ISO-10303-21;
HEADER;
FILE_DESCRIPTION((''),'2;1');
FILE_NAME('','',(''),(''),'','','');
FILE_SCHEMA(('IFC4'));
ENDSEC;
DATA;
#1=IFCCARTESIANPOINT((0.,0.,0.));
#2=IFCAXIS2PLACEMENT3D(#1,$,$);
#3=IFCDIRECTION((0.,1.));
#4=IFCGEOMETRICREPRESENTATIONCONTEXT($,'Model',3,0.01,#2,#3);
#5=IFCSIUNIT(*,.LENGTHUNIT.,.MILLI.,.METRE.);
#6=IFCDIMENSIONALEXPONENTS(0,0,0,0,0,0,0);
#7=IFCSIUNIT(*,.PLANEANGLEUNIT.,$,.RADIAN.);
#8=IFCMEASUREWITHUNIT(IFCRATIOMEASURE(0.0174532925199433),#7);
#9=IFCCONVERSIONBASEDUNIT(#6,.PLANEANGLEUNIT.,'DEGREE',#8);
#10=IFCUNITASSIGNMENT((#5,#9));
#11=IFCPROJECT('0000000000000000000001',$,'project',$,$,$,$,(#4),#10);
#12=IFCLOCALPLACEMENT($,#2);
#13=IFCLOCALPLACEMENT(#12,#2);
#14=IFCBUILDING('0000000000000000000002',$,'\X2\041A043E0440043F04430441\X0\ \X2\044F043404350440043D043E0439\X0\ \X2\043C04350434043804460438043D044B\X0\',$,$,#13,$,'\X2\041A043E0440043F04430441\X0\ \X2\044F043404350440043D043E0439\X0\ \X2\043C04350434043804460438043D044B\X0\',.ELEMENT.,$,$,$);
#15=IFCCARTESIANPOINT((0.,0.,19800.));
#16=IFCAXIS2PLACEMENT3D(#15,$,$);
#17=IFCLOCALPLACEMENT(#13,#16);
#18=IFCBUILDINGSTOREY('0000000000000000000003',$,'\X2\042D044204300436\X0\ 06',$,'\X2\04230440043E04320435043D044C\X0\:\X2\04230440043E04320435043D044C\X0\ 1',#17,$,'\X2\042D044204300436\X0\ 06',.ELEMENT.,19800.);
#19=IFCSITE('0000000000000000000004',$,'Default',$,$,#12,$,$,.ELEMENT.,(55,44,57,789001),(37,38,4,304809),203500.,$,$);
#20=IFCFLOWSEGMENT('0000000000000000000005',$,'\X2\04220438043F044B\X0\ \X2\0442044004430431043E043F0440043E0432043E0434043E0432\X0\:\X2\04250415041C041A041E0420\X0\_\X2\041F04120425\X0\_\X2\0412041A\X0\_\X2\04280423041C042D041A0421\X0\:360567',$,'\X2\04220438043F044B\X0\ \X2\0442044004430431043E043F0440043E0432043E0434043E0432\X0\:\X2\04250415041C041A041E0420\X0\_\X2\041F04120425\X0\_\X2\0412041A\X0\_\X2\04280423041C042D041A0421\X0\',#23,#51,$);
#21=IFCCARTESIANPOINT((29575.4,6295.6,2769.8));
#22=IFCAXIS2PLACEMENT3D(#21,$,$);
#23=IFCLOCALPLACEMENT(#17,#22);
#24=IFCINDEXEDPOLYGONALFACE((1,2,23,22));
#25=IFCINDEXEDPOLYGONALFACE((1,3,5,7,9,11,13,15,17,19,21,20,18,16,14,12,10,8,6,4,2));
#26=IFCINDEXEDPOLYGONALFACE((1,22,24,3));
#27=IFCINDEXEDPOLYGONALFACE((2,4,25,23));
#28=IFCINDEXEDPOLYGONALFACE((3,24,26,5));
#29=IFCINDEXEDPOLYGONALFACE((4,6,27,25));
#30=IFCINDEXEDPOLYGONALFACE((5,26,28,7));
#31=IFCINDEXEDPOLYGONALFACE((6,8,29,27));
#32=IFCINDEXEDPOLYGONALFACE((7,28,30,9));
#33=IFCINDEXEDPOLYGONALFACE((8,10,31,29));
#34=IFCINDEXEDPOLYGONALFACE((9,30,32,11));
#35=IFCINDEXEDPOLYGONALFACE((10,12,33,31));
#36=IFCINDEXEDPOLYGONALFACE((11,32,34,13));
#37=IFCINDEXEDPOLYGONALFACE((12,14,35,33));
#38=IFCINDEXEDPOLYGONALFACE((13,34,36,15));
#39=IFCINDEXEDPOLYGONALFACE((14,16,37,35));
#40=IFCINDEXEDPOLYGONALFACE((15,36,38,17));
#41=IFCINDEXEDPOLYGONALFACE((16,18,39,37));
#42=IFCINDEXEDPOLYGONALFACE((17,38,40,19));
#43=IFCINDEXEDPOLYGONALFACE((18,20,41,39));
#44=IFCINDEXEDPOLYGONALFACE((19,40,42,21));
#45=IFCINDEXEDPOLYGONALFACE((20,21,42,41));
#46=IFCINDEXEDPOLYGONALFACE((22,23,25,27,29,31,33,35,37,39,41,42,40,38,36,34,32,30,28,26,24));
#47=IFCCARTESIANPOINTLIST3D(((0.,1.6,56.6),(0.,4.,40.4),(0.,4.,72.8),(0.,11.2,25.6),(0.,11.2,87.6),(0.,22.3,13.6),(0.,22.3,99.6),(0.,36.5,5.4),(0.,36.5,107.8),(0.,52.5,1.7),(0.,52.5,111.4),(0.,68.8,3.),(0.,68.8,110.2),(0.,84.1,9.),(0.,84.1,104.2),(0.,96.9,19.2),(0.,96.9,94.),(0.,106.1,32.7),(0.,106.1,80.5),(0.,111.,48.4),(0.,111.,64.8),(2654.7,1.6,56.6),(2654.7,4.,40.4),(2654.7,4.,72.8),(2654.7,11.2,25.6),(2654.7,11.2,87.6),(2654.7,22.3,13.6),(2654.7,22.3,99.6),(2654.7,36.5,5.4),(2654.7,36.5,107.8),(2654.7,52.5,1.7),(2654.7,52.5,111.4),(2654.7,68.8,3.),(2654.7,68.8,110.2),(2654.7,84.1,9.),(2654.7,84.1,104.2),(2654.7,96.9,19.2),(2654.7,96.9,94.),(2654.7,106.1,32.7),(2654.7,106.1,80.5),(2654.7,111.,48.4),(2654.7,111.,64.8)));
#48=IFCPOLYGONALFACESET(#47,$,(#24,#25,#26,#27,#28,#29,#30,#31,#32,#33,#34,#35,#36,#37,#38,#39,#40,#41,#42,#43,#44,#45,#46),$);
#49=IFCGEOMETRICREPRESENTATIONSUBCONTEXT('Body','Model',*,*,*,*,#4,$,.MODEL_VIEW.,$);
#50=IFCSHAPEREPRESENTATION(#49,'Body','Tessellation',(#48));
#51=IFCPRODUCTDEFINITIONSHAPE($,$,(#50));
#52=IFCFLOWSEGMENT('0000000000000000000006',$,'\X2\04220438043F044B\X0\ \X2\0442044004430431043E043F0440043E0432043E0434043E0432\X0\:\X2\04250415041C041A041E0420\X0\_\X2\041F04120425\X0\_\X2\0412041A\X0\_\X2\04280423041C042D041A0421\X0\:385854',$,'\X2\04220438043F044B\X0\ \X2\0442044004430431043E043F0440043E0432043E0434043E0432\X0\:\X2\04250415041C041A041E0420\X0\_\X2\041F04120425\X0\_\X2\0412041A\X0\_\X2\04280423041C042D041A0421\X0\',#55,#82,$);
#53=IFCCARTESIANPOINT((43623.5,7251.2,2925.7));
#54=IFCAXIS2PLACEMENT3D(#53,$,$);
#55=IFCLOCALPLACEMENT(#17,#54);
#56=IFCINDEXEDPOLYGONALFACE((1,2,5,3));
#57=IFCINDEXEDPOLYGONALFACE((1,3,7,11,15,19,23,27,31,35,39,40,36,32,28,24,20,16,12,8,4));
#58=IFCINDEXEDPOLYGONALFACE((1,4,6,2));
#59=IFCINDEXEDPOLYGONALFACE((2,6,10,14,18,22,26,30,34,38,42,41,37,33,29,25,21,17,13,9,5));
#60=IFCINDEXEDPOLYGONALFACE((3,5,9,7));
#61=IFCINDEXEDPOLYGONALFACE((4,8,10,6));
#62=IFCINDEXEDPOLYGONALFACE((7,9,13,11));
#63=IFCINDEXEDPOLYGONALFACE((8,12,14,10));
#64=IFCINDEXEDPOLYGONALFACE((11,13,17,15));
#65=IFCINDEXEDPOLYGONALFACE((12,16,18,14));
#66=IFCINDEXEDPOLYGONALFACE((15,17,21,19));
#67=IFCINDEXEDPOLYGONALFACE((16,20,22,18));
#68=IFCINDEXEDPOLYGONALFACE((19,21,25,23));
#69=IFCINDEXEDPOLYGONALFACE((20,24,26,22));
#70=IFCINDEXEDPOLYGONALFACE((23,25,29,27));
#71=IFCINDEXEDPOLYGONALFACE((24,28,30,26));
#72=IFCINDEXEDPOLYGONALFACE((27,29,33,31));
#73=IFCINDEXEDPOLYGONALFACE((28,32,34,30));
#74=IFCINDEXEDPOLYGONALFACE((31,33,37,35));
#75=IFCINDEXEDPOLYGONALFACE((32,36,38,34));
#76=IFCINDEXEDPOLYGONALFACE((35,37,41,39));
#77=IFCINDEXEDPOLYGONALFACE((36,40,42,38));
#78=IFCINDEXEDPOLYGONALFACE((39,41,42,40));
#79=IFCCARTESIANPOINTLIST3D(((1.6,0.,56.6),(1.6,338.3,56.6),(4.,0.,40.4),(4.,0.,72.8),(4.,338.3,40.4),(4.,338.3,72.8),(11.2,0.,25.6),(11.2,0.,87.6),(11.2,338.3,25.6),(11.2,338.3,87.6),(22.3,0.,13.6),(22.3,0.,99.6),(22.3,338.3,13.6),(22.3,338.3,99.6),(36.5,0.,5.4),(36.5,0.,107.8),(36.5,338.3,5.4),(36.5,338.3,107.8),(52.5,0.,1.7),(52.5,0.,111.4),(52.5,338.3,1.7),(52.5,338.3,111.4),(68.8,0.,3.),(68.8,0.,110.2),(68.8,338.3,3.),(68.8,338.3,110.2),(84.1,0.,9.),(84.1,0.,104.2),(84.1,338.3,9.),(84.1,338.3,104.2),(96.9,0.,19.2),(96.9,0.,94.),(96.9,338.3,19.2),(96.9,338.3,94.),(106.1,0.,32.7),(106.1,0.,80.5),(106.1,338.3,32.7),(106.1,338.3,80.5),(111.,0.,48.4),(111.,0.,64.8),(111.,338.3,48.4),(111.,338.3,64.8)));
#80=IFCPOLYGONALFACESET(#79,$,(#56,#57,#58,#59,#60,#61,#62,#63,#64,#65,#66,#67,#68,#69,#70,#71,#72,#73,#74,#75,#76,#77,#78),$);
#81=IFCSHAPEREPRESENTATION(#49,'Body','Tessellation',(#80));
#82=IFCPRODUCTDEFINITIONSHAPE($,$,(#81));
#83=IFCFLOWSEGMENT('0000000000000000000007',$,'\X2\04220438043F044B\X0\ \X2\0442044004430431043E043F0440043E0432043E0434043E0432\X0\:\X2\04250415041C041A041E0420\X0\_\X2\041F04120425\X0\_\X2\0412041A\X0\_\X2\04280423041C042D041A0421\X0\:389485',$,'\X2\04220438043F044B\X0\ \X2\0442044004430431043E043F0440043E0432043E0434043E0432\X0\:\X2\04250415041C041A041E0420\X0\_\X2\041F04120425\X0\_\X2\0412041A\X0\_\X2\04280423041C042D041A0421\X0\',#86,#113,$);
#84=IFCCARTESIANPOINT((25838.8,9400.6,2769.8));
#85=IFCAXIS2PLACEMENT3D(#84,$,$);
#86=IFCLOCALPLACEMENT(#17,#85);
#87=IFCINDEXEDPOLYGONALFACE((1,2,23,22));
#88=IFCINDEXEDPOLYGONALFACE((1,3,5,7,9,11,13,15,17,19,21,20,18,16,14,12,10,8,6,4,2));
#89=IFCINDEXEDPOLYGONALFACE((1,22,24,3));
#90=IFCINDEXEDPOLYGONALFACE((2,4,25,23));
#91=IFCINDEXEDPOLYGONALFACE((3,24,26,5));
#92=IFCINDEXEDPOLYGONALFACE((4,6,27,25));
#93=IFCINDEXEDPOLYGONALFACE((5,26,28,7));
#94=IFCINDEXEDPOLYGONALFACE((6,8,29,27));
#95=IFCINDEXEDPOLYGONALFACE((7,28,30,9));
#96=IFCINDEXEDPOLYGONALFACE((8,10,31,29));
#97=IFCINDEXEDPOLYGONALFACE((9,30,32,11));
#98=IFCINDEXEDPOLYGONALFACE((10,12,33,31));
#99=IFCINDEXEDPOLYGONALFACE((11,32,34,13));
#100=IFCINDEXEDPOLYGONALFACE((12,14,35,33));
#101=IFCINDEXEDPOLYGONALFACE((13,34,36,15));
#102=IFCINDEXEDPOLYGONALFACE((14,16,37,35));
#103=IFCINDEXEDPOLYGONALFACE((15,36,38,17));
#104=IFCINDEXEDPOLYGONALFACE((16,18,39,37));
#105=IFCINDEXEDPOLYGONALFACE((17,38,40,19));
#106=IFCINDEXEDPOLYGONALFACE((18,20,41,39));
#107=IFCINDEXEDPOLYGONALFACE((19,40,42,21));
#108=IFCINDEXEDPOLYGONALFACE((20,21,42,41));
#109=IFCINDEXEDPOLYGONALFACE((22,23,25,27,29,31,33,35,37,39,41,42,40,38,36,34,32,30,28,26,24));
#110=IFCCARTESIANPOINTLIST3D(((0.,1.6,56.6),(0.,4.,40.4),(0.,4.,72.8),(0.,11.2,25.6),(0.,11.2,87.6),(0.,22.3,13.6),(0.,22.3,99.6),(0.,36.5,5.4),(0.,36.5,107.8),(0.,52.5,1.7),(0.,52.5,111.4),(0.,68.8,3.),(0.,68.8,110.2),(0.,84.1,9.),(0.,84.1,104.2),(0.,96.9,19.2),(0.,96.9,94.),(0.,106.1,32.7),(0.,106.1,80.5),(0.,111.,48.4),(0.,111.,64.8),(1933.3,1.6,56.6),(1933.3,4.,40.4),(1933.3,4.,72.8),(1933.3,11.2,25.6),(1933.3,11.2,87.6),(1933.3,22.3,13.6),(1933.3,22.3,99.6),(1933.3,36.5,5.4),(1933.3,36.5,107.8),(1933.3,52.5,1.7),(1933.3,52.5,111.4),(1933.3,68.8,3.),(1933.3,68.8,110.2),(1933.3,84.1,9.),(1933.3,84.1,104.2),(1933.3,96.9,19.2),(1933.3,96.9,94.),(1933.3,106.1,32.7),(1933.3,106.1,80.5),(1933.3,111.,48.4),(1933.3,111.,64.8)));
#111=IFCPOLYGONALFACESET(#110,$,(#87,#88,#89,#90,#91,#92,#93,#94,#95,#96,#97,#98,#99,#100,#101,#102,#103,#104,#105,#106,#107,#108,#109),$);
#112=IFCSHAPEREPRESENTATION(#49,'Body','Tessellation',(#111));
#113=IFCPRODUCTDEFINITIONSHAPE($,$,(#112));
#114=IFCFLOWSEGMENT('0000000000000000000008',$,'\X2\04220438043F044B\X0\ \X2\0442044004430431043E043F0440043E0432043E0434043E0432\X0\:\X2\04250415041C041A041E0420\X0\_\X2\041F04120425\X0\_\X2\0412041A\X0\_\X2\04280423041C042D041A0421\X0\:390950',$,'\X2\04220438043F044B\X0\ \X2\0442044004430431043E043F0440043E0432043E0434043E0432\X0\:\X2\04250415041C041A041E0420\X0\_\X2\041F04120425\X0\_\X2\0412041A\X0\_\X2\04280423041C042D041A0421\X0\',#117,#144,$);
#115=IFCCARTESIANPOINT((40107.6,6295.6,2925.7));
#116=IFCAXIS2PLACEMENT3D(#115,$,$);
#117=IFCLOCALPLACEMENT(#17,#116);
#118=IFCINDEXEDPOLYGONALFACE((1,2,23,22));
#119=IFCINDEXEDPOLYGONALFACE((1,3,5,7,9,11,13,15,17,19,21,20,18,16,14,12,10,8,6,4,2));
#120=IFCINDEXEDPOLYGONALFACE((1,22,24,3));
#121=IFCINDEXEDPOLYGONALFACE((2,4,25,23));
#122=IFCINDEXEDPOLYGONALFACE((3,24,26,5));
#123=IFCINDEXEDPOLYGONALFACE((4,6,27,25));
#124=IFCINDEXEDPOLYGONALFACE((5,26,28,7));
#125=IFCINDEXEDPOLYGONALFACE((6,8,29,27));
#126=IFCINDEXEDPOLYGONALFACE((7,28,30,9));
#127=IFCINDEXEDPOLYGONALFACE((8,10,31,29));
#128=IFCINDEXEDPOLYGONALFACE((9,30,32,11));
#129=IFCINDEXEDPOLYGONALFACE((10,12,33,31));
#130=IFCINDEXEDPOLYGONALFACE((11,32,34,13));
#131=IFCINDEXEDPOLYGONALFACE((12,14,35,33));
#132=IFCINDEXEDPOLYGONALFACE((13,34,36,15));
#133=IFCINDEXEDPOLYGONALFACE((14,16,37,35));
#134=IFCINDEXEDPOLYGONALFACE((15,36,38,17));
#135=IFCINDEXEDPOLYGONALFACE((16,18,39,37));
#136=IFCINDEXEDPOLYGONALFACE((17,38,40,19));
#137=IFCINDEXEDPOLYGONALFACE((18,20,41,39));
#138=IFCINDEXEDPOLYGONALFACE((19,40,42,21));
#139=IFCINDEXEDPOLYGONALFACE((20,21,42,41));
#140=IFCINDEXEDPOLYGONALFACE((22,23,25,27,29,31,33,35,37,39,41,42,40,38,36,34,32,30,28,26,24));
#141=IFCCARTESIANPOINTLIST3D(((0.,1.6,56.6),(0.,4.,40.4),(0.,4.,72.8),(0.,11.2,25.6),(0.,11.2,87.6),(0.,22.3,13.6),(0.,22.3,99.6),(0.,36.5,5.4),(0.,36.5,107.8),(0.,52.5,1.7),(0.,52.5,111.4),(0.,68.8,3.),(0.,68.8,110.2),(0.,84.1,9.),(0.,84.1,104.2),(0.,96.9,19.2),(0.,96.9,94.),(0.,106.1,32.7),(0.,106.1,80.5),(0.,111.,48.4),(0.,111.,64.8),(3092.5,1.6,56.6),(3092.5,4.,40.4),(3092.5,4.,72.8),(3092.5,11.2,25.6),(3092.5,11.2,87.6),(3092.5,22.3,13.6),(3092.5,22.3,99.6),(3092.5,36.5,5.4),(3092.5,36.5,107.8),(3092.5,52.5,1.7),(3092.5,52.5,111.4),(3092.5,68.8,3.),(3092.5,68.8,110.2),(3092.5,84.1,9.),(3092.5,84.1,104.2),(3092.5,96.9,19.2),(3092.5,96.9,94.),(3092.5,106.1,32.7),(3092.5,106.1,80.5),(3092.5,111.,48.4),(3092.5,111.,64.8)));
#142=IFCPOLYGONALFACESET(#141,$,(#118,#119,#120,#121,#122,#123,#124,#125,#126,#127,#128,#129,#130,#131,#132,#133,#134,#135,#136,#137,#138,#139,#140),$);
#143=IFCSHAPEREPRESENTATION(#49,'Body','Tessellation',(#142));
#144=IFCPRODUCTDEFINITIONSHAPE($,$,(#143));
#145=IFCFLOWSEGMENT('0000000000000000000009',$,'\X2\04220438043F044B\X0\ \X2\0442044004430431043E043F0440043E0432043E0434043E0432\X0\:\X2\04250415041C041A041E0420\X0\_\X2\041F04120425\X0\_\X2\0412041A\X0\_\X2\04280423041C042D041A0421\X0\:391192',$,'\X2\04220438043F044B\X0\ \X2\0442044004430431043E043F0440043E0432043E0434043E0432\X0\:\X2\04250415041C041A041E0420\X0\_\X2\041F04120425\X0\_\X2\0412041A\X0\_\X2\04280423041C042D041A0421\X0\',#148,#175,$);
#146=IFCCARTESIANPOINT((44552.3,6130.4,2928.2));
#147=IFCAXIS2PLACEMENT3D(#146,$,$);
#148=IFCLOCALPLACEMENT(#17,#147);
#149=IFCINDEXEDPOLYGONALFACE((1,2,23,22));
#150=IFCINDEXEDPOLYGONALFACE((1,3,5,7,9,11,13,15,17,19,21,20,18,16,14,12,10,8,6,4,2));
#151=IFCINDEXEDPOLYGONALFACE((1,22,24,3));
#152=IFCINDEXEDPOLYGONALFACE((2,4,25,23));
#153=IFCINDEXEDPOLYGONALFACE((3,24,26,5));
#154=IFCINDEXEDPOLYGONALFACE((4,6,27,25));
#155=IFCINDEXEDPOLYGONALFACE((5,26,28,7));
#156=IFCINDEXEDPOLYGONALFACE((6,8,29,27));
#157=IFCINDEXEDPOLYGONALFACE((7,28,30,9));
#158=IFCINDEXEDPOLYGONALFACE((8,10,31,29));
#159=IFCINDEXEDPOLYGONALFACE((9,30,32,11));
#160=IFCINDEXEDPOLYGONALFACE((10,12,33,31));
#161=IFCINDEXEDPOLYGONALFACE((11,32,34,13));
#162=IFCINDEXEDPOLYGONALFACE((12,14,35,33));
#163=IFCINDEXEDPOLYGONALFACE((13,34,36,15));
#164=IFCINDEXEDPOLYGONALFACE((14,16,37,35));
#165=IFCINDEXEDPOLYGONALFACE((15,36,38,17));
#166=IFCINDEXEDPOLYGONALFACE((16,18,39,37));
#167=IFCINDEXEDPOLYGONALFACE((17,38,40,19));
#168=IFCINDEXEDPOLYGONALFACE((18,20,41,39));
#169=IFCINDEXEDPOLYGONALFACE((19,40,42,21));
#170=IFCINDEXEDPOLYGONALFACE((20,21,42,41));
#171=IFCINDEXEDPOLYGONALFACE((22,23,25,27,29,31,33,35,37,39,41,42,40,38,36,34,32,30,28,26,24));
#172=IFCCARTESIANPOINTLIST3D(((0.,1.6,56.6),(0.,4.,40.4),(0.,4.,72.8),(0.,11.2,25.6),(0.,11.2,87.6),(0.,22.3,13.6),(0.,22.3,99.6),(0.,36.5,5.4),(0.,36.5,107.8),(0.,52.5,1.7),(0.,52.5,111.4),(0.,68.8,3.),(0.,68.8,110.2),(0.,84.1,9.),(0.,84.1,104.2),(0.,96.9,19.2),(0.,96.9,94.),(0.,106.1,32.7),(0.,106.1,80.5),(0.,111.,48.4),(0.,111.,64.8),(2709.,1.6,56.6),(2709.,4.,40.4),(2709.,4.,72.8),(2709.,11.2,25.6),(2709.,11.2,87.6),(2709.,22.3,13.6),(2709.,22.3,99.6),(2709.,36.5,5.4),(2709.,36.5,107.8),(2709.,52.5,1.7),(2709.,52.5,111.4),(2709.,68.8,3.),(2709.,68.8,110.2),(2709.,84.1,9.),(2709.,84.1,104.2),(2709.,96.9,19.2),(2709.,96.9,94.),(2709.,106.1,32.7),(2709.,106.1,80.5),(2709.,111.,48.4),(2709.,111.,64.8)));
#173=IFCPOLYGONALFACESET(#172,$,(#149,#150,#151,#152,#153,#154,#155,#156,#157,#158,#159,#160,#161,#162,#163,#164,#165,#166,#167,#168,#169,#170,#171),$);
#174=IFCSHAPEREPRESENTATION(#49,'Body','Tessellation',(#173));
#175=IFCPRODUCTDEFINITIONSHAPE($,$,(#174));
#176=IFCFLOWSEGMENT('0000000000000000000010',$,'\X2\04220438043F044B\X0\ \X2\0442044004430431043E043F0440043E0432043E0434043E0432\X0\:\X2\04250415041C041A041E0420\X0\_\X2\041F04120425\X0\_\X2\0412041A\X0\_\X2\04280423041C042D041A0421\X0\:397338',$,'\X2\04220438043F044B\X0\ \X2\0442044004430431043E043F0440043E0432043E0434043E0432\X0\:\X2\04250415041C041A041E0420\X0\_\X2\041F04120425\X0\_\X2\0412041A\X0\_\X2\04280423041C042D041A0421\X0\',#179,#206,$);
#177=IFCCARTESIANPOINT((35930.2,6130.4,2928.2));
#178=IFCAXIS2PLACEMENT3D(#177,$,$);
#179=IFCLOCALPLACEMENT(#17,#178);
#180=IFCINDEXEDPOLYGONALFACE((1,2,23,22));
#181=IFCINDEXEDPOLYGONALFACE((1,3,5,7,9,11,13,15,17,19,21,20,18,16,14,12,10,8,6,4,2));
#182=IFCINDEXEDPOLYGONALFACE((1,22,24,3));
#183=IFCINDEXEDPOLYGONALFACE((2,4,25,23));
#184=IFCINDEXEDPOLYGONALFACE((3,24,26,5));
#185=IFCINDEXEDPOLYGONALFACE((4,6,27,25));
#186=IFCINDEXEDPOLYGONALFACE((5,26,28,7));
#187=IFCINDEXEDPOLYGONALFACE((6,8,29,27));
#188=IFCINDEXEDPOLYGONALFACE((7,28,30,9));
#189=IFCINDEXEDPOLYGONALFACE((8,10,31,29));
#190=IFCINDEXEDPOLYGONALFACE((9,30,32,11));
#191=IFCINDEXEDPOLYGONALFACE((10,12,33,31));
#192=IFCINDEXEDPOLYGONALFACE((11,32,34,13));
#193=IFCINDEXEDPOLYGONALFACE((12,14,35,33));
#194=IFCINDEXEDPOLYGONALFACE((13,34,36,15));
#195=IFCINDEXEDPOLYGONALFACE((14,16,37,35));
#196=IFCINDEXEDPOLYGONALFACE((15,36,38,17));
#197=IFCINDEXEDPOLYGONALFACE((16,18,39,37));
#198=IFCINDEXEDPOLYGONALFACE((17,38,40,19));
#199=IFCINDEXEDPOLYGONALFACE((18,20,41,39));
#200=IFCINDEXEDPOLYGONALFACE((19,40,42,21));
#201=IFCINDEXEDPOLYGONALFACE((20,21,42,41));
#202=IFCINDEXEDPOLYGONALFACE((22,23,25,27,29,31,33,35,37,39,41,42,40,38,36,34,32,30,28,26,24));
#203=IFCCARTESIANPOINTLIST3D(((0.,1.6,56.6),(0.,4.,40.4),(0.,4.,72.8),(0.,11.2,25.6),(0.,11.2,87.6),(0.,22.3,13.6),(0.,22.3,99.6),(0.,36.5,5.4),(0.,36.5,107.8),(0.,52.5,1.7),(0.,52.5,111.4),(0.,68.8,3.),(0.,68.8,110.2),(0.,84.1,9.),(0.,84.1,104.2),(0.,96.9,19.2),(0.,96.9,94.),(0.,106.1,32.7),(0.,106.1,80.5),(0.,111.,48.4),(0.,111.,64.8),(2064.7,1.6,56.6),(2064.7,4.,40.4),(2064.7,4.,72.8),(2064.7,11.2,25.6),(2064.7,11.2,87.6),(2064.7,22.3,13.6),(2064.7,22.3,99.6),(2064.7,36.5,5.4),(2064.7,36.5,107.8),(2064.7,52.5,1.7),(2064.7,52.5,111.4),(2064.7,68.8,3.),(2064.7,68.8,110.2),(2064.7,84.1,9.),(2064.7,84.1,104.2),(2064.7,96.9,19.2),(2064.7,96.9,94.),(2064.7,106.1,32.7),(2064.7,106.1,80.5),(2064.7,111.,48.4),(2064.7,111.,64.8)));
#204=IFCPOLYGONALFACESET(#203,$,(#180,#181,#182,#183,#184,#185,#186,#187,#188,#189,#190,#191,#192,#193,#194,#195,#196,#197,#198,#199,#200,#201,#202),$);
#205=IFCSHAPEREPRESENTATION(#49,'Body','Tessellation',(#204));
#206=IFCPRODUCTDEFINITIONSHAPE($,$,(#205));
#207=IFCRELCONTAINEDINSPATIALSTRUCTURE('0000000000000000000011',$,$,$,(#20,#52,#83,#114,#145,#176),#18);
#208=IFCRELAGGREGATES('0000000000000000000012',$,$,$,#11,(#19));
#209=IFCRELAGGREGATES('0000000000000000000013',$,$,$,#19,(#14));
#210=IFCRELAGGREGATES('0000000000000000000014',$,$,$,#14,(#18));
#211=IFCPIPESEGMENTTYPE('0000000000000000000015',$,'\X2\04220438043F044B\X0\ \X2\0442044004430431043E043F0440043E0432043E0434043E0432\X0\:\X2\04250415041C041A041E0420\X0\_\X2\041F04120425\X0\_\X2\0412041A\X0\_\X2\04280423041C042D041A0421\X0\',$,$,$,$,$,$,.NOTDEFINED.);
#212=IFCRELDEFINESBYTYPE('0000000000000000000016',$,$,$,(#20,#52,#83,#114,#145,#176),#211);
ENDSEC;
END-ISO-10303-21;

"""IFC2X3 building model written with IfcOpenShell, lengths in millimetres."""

from ifc_helpers import new_model, entity, si_unit, converted_unit, direction, frame, origin, origin_2d_with_axis, place, context, subcontext, project, spatial, circle, extrude, type_object, element, save


model = new_model("IFC2X3")

# Units and contexts
model_context = context("Model", 3, precision=0.01, world=origin(), true_north=direction((0.0, 1.0)))
body_context = subcontext(model_context, "Body", "Model", "MODEL_VIEW")
ifc_project = project(units=[si_unit("LENGTHUNIT", "METRE", prefix="MILLI"), converted_unit("PLANEANGLEUNIT", "DEGREE", entity("IfcRatioMeasure", 0.0174532925199433), si_unit("PLANEANGLEUNIT", "RADIAN"), dimensions=[0, 0, 0, 0, 0, 0, 0])], contexts=[model_context])

# Site, building, storey
site_placement = place(None, frame((0.0, 0.0, 0.0)))
site = spatial("IfcSite", under=ifc_project, at=site_placement, Name="Default", CompositionType="ELEMENT", RefLatitude=(55, 44, 57, 789001), RefLongitude=(37, 38, 4, 304809), RefElevation=203500.0)
building_placement = place(site_placement, origin())
building = spatial("IfcBuilding", under=site, at=building_placement, Name="Корпус ядерной медицины", LongName="Корпус ядерной медицины", CompositionType="ELEMENT")
storey_placement = place(building_placement, frame((0.0, 0.0, 19800.0)))
storey = spatial("IfcBuildingStorey", under=building, at=storey_placement, Name="Этаж 06", ObjectType="Уровень:Уровень 1", LongName="Этаж 06", CompositionType="ELEMENT", Elevation=19800.0)

# Flow segments
pipe_segment_type = type_object("IfcPipeSegmentType", Name="Типы трубопроводов:ХЕМКОР_ПВХ_ВК_ШУМЭКС", PredefinedType="NOTDEFINED")
flow_segment_1_placement = place(storey_placement, frame((29575.4, 6295.6, 2769.8)))
element("IfcFlowSegment", 1, at=flow_segment_1_placement, inside=storey, type_object=pipe_segment_type, Name="Типы трубопроводов:ХЕМКОР_ПВХ_ВК_ШУМЭКС:360567", ObjectType="Типы трубопроводов:ХЕМКОР_ПВХ_ВК_ШУМЭКС", context=body_context, shape_type="SweptSolid", body=[
    extrude(circle(Radius=55.0, at=origin_2d_with_axis()), frame((0.0, 56.6, 56.6), z_axis=(1.0, 0.0, 0.0), x_axis=(0.0, -1.0, 0.0)), (0.0, 0.0, 1.0), 2654.7),
])
flow_segment_2_placement = place(storey_placement, frame((43623.5, 7251.2, 2925.7)))
element("IfcFlowSegment", 2, at=flow_segment_2_placement, inside=storey, type_object=pipe_segment_type, Name="Типы трубопроводов:ХЕМКОР_ПВХ_ВК_ШУМЭКС:385854", ObjectType="Типы трубопроводов:ХЕМКОР_ПВХ_ВК_ШУМЭКС", context=body_context, shape_type="SweptSolid", body=[
    extrude(circle(Radius=55.0, at=origin_2d_with_axis()), frame((56.6, 0.0, 56.6), z_axis=(0.0, 1.0, 0.0), x_axis=(-1.0, 0.0, 0.0)), (0.0, 0.0, 1.0), 338.3),
])
flow_segment_3_placement = place(storey_placement, frame((25838.8, 9400.6, 2769.8)))
element("IfcFlowSegment", 3, at=flow_segment_3_placement, inside=storey, type_object=pipe_segment_type, Name="Типы трубопроводов:ХЕМКОР_ПВХ_ВК_ШУМЭКС:389485", ObjectType="Типы трубопроводов:ХЕМКОР_ПВХ_ВК_ШУМЭКС", context=body_context, shape_type="SweptSolid", body=[
    extrude(circle(Radius=55.0, at=origin_2d_with_axis()), frame((0.0, 56.6, 56.6), z_axis=(1.0, 0.0, 0.0), x_axis=(0.0, -1.0, 0.0)), (0.0, 0.0, 1.0), 1933.3),
])
flow_segment_4_placement = place(storey_placement, frame((40107.6, 6295.6, 2925.7)))
element("IfcFlowSegment", 4, at=flow_segment_4_placement, inside=storey, type_object=pipe_segment_type, Name="Типы трубопроводов:ХЕМКОР_ПВХ_ВК_ШУМЭКС:390950", ObjectType="Типы трубопроводов:ХЕМКОР_ПВХ_ВК_ШУМЭКС", context=body_context, shape_type="SweptSolid", body=[
    extrude(circle(Radius=55.0, at=origin_2d_with_axis()), frame((0.0, 56.6, 56.6), z_axis=(1.0, 0.0, 0.0), x_axis=(0.0, -1.0, 0.0)), (0.0, 0.0, 1.0), 3092.5),
])
flow_segment_5_placement = place(storey_placement, frame((44552.3, 6130.4, 2928.2)))
element("IfcFlowSegment", 5, at=flow_segment_5_placement, inside=storey, type_object=pipe_segment_type, Name="Типы трубопроводов:ХЕМКОР_ПВХ_ВК_ШУМЭКС:391192", ObjectType="Типы трубопроводов:ХЕМКОР_ПВХ_ВК_ШУМЭКС", context=body_context, shape_type="SweptSolid", body=[
    extrude(circle(Radius=55.0, at=origin_2d_with_axis()), frame((0.0, 56.6, 56.6), z_axis=(1.0, 0.0, 0.0), x_axis=(0.0, -1.0, 0.0)), (0.0, 0.0, 1.0), 2709.0),
])
flow_segment_6_placement = place(storey_placement, frame((35930.2, 6130.4, 2928.2)))
element("IfcFlowSegment", 6, at=flow_segment_6_placement, inside=storey, type_object=pipe_segment_type, Name="Типы трубопроводов:ХЕМКОР_ПВХ_ВК_ШУМЭКС:397338", ObjectType="Типы трубопроводов:ХЕМКОР_ПВХ_ВК_ШУМЭКС", context=body_context, shape_type="SweptSolid", body=[
    extrude(circle(Radius=55.0, at=origin_2d_with_axis()), frame((0.0, 56.6, 56.6), z_axis=(1.0, 0.0, 0.0), x_axis=(0.0, -1.0, 0.0)), (0.0, 0.0, 1.0), 2064.7),
])

save(model, "model.ifc")
